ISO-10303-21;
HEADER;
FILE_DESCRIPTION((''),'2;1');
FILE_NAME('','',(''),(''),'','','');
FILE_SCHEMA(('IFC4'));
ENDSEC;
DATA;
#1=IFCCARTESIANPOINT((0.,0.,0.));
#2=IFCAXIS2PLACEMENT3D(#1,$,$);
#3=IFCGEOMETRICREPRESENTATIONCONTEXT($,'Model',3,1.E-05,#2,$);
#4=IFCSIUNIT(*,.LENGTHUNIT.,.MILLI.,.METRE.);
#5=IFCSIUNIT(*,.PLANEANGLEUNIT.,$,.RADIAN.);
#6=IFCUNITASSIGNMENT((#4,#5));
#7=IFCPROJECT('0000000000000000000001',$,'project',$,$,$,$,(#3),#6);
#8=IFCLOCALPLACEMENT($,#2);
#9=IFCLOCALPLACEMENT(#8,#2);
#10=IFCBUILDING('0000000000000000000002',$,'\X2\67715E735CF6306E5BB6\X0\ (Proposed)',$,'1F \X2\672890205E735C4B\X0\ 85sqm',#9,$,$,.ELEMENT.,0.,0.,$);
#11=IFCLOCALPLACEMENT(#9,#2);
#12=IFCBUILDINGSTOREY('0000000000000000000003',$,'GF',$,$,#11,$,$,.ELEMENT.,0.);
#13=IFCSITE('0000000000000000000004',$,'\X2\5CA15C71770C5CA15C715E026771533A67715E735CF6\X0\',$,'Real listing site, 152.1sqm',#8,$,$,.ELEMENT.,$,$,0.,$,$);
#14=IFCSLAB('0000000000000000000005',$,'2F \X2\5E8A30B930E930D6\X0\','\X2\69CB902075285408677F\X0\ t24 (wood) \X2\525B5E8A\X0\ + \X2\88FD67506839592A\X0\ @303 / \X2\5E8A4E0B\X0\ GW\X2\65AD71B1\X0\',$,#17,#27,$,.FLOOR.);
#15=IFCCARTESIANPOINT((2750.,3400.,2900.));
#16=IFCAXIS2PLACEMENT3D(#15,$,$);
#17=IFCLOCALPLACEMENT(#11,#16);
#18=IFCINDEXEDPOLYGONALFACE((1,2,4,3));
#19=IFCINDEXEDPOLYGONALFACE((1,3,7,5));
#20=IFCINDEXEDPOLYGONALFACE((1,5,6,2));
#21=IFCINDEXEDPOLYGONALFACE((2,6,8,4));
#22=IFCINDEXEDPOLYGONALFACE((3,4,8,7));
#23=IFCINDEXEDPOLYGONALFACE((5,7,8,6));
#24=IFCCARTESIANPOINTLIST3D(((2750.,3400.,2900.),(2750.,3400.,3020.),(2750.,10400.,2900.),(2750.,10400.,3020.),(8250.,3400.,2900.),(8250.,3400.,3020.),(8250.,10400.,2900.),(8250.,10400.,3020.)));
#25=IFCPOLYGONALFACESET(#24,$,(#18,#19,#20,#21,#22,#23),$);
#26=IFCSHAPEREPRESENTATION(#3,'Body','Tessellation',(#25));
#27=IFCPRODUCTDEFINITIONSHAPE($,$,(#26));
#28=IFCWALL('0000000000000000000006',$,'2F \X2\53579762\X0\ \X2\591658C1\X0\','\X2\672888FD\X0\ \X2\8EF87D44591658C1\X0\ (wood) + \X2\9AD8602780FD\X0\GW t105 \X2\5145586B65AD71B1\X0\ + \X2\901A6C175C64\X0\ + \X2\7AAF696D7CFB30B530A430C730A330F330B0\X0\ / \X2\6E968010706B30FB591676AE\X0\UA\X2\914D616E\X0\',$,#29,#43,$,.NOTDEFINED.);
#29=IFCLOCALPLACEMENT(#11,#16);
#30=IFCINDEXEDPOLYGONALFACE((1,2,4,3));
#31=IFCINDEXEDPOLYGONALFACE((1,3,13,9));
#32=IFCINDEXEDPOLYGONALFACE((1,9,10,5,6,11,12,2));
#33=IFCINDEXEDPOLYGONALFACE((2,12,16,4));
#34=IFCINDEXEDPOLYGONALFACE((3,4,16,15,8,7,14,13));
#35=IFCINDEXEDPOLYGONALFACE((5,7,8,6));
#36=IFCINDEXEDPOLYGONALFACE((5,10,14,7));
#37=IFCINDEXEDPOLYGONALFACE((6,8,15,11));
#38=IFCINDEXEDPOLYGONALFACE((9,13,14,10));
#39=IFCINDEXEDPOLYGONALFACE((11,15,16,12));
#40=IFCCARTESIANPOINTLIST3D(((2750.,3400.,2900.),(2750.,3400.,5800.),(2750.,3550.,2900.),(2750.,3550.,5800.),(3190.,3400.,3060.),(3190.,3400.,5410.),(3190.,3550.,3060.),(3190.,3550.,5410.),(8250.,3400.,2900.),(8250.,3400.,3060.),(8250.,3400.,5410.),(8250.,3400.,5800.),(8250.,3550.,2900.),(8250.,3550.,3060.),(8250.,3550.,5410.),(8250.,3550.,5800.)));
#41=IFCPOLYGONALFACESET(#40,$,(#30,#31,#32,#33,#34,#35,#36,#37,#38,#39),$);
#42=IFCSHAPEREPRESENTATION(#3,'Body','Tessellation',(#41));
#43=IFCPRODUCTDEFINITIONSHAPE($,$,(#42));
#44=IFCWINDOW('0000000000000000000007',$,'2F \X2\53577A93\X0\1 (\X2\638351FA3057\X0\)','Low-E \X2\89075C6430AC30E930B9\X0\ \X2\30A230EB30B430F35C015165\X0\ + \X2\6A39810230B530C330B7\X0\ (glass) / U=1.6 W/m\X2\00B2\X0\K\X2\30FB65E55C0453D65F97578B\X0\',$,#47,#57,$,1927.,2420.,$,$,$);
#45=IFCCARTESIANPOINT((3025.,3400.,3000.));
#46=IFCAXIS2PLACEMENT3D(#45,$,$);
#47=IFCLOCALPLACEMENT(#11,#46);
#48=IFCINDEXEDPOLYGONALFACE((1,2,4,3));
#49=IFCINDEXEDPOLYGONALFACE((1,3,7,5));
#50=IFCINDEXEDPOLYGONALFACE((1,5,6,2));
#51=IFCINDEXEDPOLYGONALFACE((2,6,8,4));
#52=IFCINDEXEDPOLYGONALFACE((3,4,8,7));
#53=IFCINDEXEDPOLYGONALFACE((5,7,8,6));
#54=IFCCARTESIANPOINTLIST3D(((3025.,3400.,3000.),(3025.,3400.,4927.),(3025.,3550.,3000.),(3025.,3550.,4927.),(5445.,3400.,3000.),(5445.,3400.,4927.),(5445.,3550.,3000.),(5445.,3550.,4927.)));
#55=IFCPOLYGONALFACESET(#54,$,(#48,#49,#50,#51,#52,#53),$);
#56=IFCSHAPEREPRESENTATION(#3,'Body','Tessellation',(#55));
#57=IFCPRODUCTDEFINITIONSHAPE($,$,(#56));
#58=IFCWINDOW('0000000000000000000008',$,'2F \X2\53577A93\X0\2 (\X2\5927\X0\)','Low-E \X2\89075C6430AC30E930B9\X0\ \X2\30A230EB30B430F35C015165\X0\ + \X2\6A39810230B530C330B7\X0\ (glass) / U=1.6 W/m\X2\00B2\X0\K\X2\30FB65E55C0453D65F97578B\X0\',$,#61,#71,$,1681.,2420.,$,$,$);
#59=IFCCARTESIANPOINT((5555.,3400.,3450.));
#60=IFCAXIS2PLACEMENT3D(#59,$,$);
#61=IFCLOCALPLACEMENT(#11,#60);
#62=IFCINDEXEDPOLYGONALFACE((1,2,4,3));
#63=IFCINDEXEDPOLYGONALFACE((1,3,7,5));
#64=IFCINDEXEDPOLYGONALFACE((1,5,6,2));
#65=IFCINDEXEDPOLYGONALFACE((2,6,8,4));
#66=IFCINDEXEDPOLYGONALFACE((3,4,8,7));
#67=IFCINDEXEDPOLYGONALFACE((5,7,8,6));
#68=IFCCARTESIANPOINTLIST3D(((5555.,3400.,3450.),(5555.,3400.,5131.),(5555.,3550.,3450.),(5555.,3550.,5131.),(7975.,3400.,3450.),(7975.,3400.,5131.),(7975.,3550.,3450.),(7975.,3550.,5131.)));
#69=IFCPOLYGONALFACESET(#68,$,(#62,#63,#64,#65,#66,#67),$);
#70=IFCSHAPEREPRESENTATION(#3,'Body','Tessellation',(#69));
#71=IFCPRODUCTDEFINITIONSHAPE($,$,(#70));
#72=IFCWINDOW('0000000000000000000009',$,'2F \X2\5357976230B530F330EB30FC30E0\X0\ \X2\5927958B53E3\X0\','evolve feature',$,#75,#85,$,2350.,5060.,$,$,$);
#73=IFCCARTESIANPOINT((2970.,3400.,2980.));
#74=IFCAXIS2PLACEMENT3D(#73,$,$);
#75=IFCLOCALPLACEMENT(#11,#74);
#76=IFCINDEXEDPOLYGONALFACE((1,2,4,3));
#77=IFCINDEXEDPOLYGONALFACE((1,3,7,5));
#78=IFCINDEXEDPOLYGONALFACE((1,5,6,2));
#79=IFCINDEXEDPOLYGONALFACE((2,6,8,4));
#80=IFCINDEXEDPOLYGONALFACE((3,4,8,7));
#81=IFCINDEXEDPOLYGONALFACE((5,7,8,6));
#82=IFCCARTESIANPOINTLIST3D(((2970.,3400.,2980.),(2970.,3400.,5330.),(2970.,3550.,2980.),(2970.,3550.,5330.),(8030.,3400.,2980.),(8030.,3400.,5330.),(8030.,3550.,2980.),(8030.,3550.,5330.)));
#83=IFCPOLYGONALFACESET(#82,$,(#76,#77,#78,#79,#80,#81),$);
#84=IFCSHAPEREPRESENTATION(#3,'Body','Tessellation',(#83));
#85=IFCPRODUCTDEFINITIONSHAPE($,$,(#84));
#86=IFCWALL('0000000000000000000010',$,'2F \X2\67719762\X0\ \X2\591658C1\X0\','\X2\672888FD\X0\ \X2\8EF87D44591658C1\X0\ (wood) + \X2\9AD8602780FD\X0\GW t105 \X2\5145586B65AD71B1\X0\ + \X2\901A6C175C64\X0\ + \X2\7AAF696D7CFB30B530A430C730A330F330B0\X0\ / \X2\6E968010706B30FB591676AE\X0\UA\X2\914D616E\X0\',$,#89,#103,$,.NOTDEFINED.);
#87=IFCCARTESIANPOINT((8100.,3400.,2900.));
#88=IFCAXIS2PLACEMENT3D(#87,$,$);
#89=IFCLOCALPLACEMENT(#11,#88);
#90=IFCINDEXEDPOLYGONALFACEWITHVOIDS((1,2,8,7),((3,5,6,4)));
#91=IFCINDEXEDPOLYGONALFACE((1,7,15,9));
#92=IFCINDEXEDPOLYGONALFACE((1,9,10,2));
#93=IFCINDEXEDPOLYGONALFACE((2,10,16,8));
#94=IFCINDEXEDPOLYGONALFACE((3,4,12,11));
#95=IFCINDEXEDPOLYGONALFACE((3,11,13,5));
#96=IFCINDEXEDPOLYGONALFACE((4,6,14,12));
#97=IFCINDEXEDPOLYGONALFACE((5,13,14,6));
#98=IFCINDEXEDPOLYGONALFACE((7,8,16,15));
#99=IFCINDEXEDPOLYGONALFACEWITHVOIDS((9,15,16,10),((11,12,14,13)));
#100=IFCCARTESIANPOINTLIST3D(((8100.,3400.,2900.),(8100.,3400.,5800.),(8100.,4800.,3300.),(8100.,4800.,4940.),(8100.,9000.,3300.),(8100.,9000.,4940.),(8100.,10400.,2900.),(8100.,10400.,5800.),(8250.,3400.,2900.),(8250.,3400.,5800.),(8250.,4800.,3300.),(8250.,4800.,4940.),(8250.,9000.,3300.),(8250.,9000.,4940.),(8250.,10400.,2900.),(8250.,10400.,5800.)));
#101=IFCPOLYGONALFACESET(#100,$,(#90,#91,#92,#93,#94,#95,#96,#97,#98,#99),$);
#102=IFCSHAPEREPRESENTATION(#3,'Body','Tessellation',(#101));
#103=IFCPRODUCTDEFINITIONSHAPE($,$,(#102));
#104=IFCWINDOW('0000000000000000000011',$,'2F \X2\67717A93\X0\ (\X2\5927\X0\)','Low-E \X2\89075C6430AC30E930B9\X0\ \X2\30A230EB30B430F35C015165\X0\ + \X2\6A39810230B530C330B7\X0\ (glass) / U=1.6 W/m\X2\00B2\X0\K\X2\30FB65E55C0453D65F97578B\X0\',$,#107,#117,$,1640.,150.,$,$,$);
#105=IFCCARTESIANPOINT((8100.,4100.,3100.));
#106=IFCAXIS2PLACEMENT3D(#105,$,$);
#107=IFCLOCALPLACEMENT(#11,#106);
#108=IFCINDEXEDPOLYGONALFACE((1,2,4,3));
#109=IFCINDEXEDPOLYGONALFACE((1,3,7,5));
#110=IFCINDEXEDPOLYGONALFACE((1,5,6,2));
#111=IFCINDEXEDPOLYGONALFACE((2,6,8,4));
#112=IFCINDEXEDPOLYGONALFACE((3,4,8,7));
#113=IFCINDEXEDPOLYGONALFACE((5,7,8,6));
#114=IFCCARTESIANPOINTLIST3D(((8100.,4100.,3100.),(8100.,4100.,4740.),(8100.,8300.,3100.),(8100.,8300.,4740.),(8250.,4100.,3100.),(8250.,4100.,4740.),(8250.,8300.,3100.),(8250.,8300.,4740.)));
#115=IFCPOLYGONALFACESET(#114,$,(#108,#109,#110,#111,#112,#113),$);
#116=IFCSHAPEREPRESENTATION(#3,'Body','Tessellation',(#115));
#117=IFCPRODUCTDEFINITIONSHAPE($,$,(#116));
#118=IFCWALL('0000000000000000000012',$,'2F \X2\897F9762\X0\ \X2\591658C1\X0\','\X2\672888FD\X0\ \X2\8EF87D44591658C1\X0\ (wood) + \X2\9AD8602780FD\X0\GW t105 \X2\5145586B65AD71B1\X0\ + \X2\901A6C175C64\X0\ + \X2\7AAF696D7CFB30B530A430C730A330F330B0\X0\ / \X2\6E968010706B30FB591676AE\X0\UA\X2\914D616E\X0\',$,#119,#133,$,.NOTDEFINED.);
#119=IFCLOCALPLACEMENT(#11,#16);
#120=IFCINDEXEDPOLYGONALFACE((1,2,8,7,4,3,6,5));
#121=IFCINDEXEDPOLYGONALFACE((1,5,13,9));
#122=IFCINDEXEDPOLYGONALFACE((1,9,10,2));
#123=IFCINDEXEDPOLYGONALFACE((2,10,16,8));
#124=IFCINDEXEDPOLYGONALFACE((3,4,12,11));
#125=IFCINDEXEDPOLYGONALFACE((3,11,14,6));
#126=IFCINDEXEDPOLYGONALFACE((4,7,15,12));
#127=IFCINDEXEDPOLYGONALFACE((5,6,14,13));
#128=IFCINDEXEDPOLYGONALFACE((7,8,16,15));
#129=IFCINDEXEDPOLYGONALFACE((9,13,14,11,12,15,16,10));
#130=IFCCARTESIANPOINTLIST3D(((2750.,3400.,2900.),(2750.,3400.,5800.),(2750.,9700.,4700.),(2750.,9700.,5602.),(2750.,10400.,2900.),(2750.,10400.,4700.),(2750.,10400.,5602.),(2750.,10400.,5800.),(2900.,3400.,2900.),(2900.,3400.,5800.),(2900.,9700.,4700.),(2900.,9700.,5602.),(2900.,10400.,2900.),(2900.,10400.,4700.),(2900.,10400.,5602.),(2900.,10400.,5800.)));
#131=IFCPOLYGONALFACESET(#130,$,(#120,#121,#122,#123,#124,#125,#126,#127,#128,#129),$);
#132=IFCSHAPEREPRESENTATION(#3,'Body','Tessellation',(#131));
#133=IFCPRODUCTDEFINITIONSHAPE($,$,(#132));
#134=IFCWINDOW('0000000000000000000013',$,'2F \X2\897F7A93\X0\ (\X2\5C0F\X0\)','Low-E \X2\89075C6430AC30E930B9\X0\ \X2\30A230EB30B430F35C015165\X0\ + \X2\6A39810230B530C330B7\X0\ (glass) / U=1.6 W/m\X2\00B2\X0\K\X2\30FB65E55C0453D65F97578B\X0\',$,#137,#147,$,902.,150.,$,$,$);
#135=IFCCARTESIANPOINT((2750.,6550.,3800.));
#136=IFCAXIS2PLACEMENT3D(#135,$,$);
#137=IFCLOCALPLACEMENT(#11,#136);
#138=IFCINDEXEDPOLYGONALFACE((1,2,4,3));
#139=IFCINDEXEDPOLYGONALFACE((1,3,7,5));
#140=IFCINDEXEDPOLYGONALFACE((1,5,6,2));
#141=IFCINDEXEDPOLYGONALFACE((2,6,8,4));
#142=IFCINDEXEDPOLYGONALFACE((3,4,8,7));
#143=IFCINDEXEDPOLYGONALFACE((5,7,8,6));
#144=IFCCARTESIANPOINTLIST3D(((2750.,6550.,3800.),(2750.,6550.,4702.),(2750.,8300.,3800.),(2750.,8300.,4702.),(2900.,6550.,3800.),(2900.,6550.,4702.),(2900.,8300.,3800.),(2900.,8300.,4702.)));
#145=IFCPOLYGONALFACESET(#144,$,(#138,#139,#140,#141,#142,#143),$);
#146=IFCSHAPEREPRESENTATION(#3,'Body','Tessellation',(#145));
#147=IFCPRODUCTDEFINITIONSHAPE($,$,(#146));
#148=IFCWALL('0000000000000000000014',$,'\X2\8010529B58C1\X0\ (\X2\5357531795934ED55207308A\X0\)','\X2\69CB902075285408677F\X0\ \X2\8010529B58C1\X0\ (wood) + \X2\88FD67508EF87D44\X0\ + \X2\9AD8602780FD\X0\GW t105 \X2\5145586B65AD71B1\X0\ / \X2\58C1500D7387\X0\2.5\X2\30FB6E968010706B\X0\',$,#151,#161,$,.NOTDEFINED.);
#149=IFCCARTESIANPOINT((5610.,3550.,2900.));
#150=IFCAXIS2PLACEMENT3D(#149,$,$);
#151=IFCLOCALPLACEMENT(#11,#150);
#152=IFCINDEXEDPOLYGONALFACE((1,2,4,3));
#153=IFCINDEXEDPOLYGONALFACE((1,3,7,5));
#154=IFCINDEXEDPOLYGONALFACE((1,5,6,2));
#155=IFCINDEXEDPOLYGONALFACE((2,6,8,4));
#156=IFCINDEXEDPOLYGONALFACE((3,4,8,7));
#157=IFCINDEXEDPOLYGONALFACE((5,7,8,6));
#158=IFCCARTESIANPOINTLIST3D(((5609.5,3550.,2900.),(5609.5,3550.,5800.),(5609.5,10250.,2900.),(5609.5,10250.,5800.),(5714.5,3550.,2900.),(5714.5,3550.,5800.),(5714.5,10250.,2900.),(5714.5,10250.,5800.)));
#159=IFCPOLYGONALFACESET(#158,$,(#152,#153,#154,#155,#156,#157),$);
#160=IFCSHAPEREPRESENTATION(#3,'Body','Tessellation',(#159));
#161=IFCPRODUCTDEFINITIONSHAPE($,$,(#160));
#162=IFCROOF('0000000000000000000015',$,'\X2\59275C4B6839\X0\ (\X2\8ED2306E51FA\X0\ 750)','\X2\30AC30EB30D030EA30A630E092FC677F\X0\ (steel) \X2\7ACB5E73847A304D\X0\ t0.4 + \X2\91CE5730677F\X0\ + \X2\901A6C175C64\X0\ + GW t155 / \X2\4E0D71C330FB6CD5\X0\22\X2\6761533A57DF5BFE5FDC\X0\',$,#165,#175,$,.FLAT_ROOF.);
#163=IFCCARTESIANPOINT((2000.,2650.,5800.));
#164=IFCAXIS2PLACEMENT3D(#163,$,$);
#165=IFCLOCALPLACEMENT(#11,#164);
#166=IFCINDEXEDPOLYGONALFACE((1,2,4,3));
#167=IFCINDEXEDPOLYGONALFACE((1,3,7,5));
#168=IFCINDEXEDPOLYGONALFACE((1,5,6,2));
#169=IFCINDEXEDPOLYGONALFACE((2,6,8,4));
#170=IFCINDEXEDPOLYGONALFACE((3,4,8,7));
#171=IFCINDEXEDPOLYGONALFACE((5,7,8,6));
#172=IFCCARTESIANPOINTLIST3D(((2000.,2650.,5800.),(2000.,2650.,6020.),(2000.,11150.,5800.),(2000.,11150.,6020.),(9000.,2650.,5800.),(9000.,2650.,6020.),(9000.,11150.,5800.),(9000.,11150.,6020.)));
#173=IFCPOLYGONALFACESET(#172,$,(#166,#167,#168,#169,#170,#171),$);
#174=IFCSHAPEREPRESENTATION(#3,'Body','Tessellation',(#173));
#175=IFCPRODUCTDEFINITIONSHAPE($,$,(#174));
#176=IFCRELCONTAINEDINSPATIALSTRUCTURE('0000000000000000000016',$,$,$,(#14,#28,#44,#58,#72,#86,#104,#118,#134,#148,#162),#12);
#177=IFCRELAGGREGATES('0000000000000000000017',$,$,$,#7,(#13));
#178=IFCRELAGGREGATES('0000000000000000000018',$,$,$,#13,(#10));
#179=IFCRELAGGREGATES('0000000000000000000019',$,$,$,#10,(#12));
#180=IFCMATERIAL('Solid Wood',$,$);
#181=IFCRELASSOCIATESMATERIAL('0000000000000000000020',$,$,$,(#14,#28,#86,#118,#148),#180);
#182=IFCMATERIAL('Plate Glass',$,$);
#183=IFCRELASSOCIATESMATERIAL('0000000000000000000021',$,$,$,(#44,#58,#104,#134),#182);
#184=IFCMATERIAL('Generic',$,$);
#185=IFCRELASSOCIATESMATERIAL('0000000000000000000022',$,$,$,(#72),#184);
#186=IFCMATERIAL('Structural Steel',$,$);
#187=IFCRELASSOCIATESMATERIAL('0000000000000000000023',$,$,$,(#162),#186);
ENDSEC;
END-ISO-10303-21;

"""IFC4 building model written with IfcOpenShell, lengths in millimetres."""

from ifc_helpers import new_model, si_unit, frame, frame_2d, origin, place, context, project, spatial, rectangle, extrude, material, element, fill, save


model = new_model("IFC4")

# Units and contexts
model_context = context("Model", 3, precision=1e-05, world=origin())
ifc_project = project(units=[si_unit("LENGTHUNIT", "METRE", prefix="MILLI"), si_unit("PLANEANGLEUNIT", "RADIAN")], contexts=[model_context])

# Site, building, storey
site_placement = place(None, origin())
site = spatial("IfcSite", under=ifc_project, at=site_placement, Name="岡山県岡山市東区東平島", ObjectType="Real listing site, 152.1sqm", CompositionType="ELEMENT", RefElevation=0.0)
building_placement = place(site_placement, origin())
building = spatial("IfcBuilding", under=site, at=building_placement, Name="東平島の家 (Proposed)", ObjectType="1F 木造平屋 85sqm", CompositionType="ELEMENT", ElevationOfRefHeight=0.0, ElevationOfTerrain=0.0)
storey_placement = place(building_placement, origin())
storey = spatial("IfcBuildingStorey", under=building, at=storey_placement, Name="GF", CompositionType="ELEMENT", Elevation=0.0)

# Slab
ifc_material_1 = material(Name="Solid Wood")
slab_placement = place(storey_placement, frame((2750.0, 3400.0, 2900.0)))
element("IfcSlab", 1, at=slab_placement, inside=storey, material=ifc_material_1, Name="2F 床スラブ", Description="構造用合板 t24 (wood) 剛床 + 製材根太 @303 / 床下 GW断熱", PredefinedType="FLOOR", context=model_context, shape_type="SweptSolid", body=[
    extrude(rectangle(XDim=5500.0, YDim=7000.0, at=frame_2d((2750.0, 3500.0))), frame((2750.0, 3400.0, 2900.0)), (0.0, 0.0, 1.0), 120.0),
])

# Wall, openings, windows
wall_1_placement = place(storey_placement, frame((2750.0, 3400.0, 2900.0)))
wall_1 = element("IfcWall", 2, at=wall_1_placement, inside=storey, material=ifc_material_1, Name="2F 南面 外壁", Description="木製 軸組外壁 (wood) + 高性能GW t105 充填断熱 + 通気層 + 窯業系サイディング / 準耐火・外皮UA配慮", PredefinedType="NOTDEFINED", context=model_context, shape_type="SweptSolid", body=[
    extrude(rectangle(XDim=5500.0, YDim=150.0, at=frame_2d((2750.0, 75.0))), frame((2750.0, 3400.0, 2900.0)), (0.0, 0.0, 1.0), 2900.0),
])
opening_1_placement = place(storey_placement, frame((3025.0, 3400.0, 3000.0)))
opening_1 = element("IfcOpeningElement", 3, at=opening_1_placement, cuts=wall_1, PredefinedType="NOTDEFINED", context=model_context, shape_type="SweptSolid", body=[
    extrude(rectangle(XDim=2420.0, YDim=150.0, at=frame_2d((1210.0, 75.0))), frame((3025.0, 3400.0, 3000.0)), (0.0, 0.0, 1.0), 1927.0),
])
opening_2_placement = place(storey_placement, frame((5555.0, 3400.0, 3450.0)))
opening_2 = element("IfcOpeningElement", 4, at=opening_2_placement, cuts=wall_1, PredefinedType="NOTDEFINED", context=model_context, shape_type="SweptSolid", body=[
    extrude(rectangle(XDim=2420.0, YDim=150.0, at=frame_2d((1210.0, 75.0))), frame((5555.0, 3400.0, 3450.0)), (0.0, 0.0, 1.0), 1681.0),
])
opening_3_placement = place(storey_placement, frame((2970.0, 3400.0, 2980.0)))
opening_3 = element("IfcOpeningElement", 5, at=opening_3_placement, cuts=wall_1, PredefinedType="NOTDEFINED", context=model_context, shape_type="SweptSolid", body=[
    extrude(rectangle(XDim=5060.0, YDim=150.0, at=frame_2d((2530.0, 75.0))), frame((2970.0, 3400.0, 2980.0)), (0.0, 0.0, 1.0), 2350.0),
])
ifc_material_2 = material(Name="Plate Glass")
window_1_placement = place(storey_placement, frame((3025.0, 3400.0, 3000.0)))
window_1 = element("IfcWindow", 6, at=window_1_placement, inside=storey, material=ifc_material_2, Name="2F 南窓1 (掃出し)", Description="Low-E 複層ガラス アルゴン封入 + 樹脂サッシ (glass) / U=1.6 W/m²K・日射取得型", OverallHeight=1927.0, OverallWidth=2420.0, context=model_context, shape_type="SweptSolid", body=[
    extrude(rectangle(XDim=2420.0, YDim=150.0, at=frame_2d((1210.0, 75.0))), frame((3025.0, 3400.0, 3000.0)), (0.0, 0.0, 1.0), 1927.0),
])
fill(opening_1, window_1)
window_2_placement = place(storey_placement, frame((5555.0, 3400.0, 3450.0)))
window_2 = element("IfcWindow", 7, at=window_2_placement, inside=storey, material=ifc_material_2, Name="2F 南窓2 (大)", Description="Low-E 複層ガラス アルゴン封入 + 樹脂サッシ (glass) / U=1.6 W/m²K・日射取得型", OverallHeight=1681.0, OverallWidth=2420.0, context=model_context, shape_type="SweptSolid", body=[
    extrude(rectangle(XDim=2420.0, YDim=150.0, at=frame_2d((1210.0, 75.0))), frame((5555.0, 3400.0, 3450.0)), (0.0, 0.0, 1.0), 1681.0),
])
fill(opening_2, window_2)
ifc_material_3 = material(Name="Generic")
window_3_placement = place(storey_placement, frame((2970.0, 3400.0, 2980.0)))
window_3 = element("IfcWindow", 8, at=window_3_placement, inside=storey, material=ifc_material_3, Name="2F 南面サンルーム 大開口", Description="evolve feature", OverallHeight=2350.0, OverallWidth=5060.0, context=model_context, shape_type="SweptSolid", body=[
    extrude(rectangle(XDim=5060.0, YDim=150.0, at=frame_2d((2530.0, 75.0))), frame((2970.0, 3400.0, 2980.0)), (0.0, 0.0, 1.0), 2350.0),
])
fill(opening_3, window_3)

# Walls, openings, windows
wall_2_placement = place(storey_placement, frame((8100.0, 3400.0, 2900.0)))
wall_2 = element("IfcWall", 9, at=wall_2_placement, inside=storey, material=ifc_material_1, Name="2F 東面 外壁", Description="木製 軸組外壁 (wood) + 高性能GW t105 充填断熱 + 通気層 + 窯業系サイディング / 準耐火・外皮UA配慮", PredefinedType="NOTDEFINED", context=model_context, shape_type="SweptSolid", body=[
    extrude(rectangle(XDim=150.0, YDim=7000.0, at=frame_2d((75.0, 3500.0))), frame((8100.0, 3400.0, 2900.0)), (0.0, 0.0, 1.0), 2900.0),
])
opening_4_placement = place(storey_placement, frame((8100.0, 4100.0, 3100.0)))
opening_4 = element("IfcOpeningElement", 10, at=opening_4_placement, cuts=wall_2, PredefinedType="NOTDEFINED", context=model_context, shape_type="SweptSolid", body=[
    extrude(rectangle(XDim=150.0, YDim=4200.0, at=frame_2d((75.0, 2100.0))), frame((8100.0, 4100.0, 3100.0)), (0.0, 0.0, 1.0), 1640.0),
])
window_4_placement = place(storey_placement, frame((8100.0, 4100.0, 3100.0)))
window_4 = element("IfcWindow", 11, at=window_4_placement, inside=storey, material=ifc_material_2, Name="2F 東窓 (大)", Description="Low-E 複層ガラス アルゴン封入 + 樹脂サッシ (glass) / U=1.6 W/m²K・日射取得型", OverallHeight=1640.0, OverallWidth=150.0, context=model_context, shape_type="SweptSolid", body=[
    extrude(rectangle(XDim=150.0, YDim=4200.0, at=frame_2d((75.0, 2100.0))), frame((8100.0, 4100.0, 3100.0)), (0.0, 0.0, 1.0), 1640.0),
])
fill(opening_4, window_4)
wall_3_placement = place(storey_placement, frame((2750.0, 3400.0, 2900.0)))
wall_3 = element("IfcWall", 12, at=wall_3_placement, inside=storey, material=ifc_material_1, Name="2F 西面 外壁", Description="木製 軸組外壁 (wood) + 高性能GW t105 充填断熱 + 通気層 + 窯業系サイディング / 準耐火・外皮UA配慮", PredefinedType="NOTDEFINED", context=model_context, shape_type="SweptSolid", body=[
    extrude(rectangle(XDim=150.0, YDim=7000.0, at=frame_2d((75.0, 3500.0))), frame((2750.0, 3400.0, 2900.0)), (0.0, 0.0, 1.0), 2900.0),
])
opening_5_placement = place(storey_placement, frame((2750.0, 6550.0, 3800.0)))
opening_5 = element("IfcOpeningElement", 13, at=opening_5_placement, cuts=wall_3, PredefinedType="NOTDEFINED", context=model_context, shape_type="SweptSolid", body=[
    extrude(rectangle(XDim=150.0, YDim=1750.0, at=frame_2d((75.0, 875.0))), frame((2750.0, 6550.0, 3800.0)), (0.0, 0.0, 1.0), 902.0),
])
window_5_placement = place(storey_placement, frame((2750.0, 6550.0, 3800.0)))
window_5 = element("IfcWindow", 14, at=window_5_placement, inside=storey, material=ifc_material_2, Name="2F 西窓 (小)", Description="Low-E 複層ガラス アルゴン封入 + 樹脂サッシ (glass) / U=1.6 W/m²K・日射取得型", OverallHeight=902.0, OverallWidth=150.0, context=model_context, shape_type="SweptSolid", body=[
    extrude(rectangle(XDim=150.0, YDim=1750.0, at=frame_2d((75.0, 875.0))), frame((2750.0, 6550.0, 3800.0)), (0.0, 0.0, 1.0), 902.0),
])
fill(opening_5, window_5)

# Wall
wall_4_placement = place(storey_placement, frame((5610.0, 3550.0, 2900.0)))
element("IfcWall", 15, at=wall_4_placement, inside=storey, material=ifc_material_1, Name="耐力壁 (南北間仕切り)", Description="構造用合板 耐力壁 (wood) + 製材軸組 + 高性能GW t105 充填断熱 / 壁倍率2.5・準耐火", PredefinedType="NOTDEFINED", context=model_context, shape_type="SweptSolid", body=[
    extrude(rectangle(XDim=105.0, YDim=6700.0, at=frame_2d((52.0, 3350.0))), frame((5610.0, 3550.0, 2900.0)), (0.0, 0.0, 1.0), 2900.0),
])

# Roof
ifc_material_4 = material(Name="Structural Steel")
roof_placement = place(storey_placement, frame((2000.0, 2650.0, 5800.0)))
element("IfcRoof", 16, at=roof_placement, inside=storey, material=ifc_material_4, Name="大屋根 (軒の出 750)", Description="ガルバリウム鋼板 (steel) 立平葺き t0.4 + 野地板 + 通気層 + GW t155 / 不燃・法22条区域対応", PredefinedType="FLAT_ROOF", context=model_context, shape_type="SweptSolid", body=[
    extrude(rectangle(XDim=7000.0, YDim=8500.0, at=frame_2d((3500.0, 4250.0))), frame((2000.0, 2650.0, 5800.0)), (0.0, 0.0, 1.0), 220.0),
])

save(model, "model.ifc")
